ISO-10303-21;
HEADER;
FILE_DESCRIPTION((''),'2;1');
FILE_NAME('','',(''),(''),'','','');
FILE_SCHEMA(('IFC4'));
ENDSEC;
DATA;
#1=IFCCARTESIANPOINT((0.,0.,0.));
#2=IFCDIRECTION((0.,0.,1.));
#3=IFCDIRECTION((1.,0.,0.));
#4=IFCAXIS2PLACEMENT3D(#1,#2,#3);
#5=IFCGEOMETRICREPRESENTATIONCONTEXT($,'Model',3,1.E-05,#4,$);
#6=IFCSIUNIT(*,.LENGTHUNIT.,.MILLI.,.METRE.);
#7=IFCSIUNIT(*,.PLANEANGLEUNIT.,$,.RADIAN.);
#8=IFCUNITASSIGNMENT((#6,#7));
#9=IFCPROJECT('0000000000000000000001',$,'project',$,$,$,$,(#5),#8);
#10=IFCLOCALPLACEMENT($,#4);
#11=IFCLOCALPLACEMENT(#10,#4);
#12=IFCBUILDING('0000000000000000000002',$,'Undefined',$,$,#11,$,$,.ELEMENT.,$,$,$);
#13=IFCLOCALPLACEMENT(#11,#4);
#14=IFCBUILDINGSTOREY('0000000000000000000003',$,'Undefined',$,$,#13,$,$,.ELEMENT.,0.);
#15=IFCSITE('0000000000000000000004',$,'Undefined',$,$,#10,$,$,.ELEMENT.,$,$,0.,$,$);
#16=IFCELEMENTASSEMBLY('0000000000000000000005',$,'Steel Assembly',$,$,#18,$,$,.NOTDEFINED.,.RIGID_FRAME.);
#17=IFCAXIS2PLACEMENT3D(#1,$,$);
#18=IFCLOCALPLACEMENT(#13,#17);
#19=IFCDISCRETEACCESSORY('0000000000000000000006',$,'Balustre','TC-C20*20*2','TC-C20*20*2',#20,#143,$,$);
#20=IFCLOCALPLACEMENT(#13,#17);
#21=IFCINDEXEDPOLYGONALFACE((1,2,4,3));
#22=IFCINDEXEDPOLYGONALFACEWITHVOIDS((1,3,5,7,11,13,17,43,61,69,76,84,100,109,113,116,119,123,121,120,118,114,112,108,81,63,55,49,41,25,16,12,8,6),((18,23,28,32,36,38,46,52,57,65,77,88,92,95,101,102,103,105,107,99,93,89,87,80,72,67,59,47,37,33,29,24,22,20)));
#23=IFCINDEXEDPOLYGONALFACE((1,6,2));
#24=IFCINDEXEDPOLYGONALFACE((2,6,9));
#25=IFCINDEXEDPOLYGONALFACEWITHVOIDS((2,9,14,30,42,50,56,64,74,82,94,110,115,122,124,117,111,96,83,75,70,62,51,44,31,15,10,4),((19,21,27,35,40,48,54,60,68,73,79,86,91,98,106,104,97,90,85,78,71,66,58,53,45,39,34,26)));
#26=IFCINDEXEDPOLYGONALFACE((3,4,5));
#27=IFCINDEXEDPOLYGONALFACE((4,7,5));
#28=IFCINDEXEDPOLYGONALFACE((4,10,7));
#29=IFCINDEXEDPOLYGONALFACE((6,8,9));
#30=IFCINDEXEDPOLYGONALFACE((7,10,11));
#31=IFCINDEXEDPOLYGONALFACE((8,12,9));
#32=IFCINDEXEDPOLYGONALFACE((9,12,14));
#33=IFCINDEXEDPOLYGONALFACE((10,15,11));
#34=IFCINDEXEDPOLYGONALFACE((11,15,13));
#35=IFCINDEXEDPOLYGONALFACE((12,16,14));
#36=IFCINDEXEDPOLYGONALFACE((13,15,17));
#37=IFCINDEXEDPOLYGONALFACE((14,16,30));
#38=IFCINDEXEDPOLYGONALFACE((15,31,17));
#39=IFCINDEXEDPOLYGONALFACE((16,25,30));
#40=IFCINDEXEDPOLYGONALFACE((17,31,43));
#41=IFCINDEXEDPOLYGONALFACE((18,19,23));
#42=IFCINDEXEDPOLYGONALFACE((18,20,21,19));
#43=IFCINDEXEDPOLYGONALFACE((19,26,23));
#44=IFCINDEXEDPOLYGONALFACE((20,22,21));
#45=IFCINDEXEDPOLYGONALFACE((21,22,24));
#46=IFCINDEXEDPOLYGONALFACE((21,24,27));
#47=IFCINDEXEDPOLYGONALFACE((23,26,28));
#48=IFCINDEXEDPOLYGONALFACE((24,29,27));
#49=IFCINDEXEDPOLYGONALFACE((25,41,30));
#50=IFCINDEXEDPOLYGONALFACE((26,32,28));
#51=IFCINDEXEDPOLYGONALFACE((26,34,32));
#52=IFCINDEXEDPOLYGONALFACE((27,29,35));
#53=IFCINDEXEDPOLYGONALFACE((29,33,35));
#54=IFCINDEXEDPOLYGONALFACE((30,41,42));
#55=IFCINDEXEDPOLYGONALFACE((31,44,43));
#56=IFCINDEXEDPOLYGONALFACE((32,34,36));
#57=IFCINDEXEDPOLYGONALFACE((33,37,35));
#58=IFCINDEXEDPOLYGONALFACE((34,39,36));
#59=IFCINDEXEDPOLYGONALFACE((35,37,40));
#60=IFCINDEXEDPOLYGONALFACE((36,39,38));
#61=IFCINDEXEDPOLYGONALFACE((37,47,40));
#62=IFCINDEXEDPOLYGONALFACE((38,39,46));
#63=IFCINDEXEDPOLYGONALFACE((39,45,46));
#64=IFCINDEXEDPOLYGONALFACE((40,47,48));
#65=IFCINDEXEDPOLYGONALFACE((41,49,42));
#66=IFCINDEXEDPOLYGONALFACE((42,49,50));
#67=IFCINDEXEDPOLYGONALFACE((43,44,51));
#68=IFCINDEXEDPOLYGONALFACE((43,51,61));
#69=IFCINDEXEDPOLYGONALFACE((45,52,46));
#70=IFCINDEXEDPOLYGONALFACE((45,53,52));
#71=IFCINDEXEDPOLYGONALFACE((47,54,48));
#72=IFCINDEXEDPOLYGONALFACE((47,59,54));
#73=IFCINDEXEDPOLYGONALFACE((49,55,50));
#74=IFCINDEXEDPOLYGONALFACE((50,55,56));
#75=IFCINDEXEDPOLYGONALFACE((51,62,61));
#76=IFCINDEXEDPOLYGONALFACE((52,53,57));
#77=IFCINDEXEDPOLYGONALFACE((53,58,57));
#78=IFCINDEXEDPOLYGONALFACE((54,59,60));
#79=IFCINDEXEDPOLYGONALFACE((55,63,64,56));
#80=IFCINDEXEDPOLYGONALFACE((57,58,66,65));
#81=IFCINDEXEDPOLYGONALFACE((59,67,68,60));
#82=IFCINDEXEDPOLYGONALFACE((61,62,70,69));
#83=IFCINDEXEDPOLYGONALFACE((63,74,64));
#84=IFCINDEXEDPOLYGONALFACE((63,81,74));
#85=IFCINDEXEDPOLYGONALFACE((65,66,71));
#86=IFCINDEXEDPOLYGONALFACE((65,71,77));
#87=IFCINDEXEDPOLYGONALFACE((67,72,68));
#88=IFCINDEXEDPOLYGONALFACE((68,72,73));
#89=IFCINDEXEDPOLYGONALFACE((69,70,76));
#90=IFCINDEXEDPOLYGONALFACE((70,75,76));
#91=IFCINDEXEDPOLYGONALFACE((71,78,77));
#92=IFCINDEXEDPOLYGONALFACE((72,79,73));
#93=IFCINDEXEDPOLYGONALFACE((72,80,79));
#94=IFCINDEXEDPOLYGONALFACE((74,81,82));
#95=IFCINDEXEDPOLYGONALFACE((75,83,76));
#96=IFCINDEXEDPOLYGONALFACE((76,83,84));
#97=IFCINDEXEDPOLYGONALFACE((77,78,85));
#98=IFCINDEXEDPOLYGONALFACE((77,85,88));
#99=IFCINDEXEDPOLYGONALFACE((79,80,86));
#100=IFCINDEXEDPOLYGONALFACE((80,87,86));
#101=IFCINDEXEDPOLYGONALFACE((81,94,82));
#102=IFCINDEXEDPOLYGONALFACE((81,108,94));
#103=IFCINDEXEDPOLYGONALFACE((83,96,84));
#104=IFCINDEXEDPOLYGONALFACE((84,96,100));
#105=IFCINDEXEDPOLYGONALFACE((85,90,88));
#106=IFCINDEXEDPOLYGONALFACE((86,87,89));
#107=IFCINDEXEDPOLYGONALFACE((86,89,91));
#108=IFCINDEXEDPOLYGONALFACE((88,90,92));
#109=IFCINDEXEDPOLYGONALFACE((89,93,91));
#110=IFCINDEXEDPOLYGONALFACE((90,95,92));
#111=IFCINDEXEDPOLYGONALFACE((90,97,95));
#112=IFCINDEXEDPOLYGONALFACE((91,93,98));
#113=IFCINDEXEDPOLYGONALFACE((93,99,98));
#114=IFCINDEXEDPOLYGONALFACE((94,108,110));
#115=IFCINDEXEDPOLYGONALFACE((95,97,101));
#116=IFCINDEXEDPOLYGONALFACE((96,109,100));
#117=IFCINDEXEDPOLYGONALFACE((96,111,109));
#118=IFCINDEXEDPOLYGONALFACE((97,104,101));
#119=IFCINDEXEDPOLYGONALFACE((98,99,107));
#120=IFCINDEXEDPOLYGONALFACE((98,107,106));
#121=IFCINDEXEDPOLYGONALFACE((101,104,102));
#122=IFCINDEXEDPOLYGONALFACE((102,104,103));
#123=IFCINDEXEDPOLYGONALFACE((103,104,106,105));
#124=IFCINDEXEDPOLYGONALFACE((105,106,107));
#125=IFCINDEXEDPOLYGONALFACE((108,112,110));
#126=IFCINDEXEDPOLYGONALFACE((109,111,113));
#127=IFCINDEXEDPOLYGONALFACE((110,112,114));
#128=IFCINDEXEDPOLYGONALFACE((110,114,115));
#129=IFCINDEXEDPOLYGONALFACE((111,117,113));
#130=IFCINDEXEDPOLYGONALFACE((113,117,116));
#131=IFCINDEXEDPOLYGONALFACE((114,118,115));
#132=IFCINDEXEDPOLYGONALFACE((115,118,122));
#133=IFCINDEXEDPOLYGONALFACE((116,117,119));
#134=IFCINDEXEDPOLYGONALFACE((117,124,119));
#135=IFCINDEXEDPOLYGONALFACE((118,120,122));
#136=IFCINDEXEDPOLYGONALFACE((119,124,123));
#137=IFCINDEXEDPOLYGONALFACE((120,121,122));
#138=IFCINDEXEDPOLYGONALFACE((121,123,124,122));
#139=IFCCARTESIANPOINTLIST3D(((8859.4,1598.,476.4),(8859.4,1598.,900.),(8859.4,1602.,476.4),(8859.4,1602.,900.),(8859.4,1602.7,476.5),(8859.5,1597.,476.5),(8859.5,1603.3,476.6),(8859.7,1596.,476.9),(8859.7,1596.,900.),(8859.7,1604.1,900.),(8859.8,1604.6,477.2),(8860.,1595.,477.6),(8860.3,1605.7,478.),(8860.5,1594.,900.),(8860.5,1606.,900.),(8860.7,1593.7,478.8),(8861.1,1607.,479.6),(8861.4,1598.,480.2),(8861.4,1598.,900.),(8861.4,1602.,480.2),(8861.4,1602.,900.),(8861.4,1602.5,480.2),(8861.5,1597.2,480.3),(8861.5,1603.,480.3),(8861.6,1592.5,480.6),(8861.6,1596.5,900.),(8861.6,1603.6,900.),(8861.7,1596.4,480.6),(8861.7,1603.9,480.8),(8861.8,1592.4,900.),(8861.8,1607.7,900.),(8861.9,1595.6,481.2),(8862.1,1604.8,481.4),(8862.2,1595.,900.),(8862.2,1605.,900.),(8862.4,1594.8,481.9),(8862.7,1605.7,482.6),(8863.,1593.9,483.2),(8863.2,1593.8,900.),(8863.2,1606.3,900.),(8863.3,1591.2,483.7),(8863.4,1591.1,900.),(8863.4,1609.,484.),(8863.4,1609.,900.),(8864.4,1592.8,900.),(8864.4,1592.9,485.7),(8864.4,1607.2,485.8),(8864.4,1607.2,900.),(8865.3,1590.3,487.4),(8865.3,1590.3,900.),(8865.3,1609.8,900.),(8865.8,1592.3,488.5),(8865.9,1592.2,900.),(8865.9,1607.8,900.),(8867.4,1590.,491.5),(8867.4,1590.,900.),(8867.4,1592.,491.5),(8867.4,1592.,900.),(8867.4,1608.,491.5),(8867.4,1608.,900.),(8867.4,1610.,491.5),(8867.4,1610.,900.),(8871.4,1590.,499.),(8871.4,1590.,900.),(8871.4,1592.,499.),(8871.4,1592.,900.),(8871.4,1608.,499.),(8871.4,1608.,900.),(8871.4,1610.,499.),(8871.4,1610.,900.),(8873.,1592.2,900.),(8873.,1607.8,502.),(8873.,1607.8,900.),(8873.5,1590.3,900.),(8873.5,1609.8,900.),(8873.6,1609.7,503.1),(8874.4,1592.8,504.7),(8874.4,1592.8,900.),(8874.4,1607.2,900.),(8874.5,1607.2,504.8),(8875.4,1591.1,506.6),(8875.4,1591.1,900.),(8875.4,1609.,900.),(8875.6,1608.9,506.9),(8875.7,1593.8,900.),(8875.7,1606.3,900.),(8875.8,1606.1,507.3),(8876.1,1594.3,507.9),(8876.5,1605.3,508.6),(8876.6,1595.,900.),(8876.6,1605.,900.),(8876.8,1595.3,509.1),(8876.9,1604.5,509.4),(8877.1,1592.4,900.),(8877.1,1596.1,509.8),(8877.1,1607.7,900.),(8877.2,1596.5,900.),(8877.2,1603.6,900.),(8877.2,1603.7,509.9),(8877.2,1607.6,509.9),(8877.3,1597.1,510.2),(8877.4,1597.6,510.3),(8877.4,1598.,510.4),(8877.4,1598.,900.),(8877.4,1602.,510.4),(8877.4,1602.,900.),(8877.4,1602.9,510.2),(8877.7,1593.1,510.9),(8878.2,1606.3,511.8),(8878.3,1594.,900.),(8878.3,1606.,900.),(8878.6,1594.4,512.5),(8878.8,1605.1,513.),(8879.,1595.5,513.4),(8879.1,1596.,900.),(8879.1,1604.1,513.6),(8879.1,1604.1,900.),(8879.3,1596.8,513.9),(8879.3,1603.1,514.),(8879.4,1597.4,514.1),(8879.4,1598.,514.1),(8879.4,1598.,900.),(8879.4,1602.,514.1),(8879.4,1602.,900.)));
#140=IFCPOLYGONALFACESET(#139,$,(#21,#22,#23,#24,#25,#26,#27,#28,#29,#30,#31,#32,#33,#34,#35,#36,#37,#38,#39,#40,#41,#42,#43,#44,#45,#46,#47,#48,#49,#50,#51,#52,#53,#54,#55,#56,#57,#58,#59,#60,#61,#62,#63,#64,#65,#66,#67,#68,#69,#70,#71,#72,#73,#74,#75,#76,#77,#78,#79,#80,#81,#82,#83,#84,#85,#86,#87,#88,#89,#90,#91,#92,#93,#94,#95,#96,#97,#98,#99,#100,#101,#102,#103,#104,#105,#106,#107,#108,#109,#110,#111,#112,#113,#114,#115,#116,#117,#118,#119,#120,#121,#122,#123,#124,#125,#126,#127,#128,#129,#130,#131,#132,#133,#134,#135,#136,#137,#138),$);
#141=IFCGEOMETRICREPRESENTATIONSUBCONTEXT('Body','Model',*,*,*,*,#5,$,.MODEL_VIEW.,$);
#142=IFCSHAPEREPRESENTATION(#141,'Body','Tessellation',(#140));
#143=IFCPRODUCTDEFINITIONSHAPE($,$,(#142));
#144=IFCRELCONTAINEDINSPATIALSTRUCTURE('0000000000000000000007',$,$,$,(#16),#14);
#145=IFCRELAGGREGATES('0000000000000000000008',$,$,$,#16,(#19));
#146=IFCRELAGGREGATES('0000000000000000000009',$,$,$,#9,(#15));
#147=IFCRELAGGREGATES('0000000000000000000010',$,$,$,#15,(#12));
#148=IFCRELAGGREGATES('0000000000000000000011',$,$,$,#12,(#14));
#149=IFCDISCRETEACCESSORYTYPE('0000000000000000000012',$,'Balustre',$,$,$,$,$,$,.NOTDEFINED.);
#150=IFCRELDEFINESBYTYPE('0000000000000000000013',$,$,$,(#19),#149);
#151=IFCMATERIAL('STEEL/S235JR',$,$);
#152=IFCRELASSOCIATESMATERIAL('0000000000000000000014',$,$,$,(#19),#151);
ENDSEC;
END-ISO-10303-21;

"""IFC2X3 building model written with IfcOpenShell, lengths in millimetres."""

from ifc_helpers import new_model, si_unit, frame, origin_with_axes, origin_2d_with_axis, place, context, subcontext, project, spatial, hollow_rectangle, extrude, clip, halfspace, material, type_object, element, aggregate, save


model = new_model("IFC2X3")

# Units and contexts
model_context = context("Model", 3, precision=1e-05, world=origin_with_axes())
body_context = subcontext(model_context, "Body", "Model", "MODEL_VIEW")
ifc_project = project(units=[si_unit("LENGTHUNIT", "METRE", prefix="MILLI"), si_unit("PLANEANGLEUNIT", "RADIAN")], contexts=[model_context])

# Site, building, storey
site_placement = place(None, origin_with_axes())
site = spatial("IfcSite", under=ifc_project, at=site_placement, Name="Undefined", CompositionType="ELEMENT", RefElevation=0.0)
building_placement = place(site_placement, origin_with_axes())
building = spatial("IfcBuilding", under=site, at=building_placement, Name="Undefined", CompositionType="ELEMENT")
storey_placement = place(building_placement, origin_with_axes())
storey = spatial("IfcBuildingStorey", under=building, at=storey_placement, Name="Undefined", CompositionType="ELEMENT", Elevation=0.0)

# Shared definitions
ifc_material = material(Name="STEEL/S235JR")

# Element assembly, discrete accessory
discrete_accessory_type_1 = type_object("IfcDiscreteAccessoryType", Name="Balustre")
assembly_1_placement = place(storey_placement, origin_with_axes())
assembly_1 = element("IfcElementAssembly", 1, at=assembly_1_placement, inside=storey, Name="Steel Assembly", AssemblyPlace="NOTDEFINED", PredefinedType="RIGID_FRAME")
discrete_accessory_1_placement = place(assembly_1_placement, frame((8869.4, 1600.0, 900.0), z_axis=(-0.000011, 1.0, 0.0), x_axis=(0.0, 0.0, -1.0)))
discrete_accessory_1 = element("IfcDiscreteAccessory", 2, at=discrete_accessory_1_placement, type_object=discrete_accessory_type_1, material=ifc_material, Name="Balustre", Description="TC-C20*20*2", ObjectType="TC-C20*20*2", context=body_context, shape_type="Clipping", body=[
    clip(extrude(hollow_rectangle(XDim=20.0, YDim=20.0, WallThickness=2.0, InnerFilletRadius=6.0, OuterFilletRadius=8.0, at=origin_2d_with_axis()), frame((423.8, 0.0, 0.0), z_axis=(-1.0, 0.0, 0.0), x_axis=(0.0, -1.0, 0.0)), (0.0, 0.0, 1.0), 423.8), halfspace(frame((429.9, 13.3, 0.0), z_axis=(-0.46842, 0.883506, 0.000005), x_axis=(0.0, -0.000005, 1.0)), True)),
])

aggregate(assembly_1, [discrete_accessory_1])

save(model, "model.ifc")
